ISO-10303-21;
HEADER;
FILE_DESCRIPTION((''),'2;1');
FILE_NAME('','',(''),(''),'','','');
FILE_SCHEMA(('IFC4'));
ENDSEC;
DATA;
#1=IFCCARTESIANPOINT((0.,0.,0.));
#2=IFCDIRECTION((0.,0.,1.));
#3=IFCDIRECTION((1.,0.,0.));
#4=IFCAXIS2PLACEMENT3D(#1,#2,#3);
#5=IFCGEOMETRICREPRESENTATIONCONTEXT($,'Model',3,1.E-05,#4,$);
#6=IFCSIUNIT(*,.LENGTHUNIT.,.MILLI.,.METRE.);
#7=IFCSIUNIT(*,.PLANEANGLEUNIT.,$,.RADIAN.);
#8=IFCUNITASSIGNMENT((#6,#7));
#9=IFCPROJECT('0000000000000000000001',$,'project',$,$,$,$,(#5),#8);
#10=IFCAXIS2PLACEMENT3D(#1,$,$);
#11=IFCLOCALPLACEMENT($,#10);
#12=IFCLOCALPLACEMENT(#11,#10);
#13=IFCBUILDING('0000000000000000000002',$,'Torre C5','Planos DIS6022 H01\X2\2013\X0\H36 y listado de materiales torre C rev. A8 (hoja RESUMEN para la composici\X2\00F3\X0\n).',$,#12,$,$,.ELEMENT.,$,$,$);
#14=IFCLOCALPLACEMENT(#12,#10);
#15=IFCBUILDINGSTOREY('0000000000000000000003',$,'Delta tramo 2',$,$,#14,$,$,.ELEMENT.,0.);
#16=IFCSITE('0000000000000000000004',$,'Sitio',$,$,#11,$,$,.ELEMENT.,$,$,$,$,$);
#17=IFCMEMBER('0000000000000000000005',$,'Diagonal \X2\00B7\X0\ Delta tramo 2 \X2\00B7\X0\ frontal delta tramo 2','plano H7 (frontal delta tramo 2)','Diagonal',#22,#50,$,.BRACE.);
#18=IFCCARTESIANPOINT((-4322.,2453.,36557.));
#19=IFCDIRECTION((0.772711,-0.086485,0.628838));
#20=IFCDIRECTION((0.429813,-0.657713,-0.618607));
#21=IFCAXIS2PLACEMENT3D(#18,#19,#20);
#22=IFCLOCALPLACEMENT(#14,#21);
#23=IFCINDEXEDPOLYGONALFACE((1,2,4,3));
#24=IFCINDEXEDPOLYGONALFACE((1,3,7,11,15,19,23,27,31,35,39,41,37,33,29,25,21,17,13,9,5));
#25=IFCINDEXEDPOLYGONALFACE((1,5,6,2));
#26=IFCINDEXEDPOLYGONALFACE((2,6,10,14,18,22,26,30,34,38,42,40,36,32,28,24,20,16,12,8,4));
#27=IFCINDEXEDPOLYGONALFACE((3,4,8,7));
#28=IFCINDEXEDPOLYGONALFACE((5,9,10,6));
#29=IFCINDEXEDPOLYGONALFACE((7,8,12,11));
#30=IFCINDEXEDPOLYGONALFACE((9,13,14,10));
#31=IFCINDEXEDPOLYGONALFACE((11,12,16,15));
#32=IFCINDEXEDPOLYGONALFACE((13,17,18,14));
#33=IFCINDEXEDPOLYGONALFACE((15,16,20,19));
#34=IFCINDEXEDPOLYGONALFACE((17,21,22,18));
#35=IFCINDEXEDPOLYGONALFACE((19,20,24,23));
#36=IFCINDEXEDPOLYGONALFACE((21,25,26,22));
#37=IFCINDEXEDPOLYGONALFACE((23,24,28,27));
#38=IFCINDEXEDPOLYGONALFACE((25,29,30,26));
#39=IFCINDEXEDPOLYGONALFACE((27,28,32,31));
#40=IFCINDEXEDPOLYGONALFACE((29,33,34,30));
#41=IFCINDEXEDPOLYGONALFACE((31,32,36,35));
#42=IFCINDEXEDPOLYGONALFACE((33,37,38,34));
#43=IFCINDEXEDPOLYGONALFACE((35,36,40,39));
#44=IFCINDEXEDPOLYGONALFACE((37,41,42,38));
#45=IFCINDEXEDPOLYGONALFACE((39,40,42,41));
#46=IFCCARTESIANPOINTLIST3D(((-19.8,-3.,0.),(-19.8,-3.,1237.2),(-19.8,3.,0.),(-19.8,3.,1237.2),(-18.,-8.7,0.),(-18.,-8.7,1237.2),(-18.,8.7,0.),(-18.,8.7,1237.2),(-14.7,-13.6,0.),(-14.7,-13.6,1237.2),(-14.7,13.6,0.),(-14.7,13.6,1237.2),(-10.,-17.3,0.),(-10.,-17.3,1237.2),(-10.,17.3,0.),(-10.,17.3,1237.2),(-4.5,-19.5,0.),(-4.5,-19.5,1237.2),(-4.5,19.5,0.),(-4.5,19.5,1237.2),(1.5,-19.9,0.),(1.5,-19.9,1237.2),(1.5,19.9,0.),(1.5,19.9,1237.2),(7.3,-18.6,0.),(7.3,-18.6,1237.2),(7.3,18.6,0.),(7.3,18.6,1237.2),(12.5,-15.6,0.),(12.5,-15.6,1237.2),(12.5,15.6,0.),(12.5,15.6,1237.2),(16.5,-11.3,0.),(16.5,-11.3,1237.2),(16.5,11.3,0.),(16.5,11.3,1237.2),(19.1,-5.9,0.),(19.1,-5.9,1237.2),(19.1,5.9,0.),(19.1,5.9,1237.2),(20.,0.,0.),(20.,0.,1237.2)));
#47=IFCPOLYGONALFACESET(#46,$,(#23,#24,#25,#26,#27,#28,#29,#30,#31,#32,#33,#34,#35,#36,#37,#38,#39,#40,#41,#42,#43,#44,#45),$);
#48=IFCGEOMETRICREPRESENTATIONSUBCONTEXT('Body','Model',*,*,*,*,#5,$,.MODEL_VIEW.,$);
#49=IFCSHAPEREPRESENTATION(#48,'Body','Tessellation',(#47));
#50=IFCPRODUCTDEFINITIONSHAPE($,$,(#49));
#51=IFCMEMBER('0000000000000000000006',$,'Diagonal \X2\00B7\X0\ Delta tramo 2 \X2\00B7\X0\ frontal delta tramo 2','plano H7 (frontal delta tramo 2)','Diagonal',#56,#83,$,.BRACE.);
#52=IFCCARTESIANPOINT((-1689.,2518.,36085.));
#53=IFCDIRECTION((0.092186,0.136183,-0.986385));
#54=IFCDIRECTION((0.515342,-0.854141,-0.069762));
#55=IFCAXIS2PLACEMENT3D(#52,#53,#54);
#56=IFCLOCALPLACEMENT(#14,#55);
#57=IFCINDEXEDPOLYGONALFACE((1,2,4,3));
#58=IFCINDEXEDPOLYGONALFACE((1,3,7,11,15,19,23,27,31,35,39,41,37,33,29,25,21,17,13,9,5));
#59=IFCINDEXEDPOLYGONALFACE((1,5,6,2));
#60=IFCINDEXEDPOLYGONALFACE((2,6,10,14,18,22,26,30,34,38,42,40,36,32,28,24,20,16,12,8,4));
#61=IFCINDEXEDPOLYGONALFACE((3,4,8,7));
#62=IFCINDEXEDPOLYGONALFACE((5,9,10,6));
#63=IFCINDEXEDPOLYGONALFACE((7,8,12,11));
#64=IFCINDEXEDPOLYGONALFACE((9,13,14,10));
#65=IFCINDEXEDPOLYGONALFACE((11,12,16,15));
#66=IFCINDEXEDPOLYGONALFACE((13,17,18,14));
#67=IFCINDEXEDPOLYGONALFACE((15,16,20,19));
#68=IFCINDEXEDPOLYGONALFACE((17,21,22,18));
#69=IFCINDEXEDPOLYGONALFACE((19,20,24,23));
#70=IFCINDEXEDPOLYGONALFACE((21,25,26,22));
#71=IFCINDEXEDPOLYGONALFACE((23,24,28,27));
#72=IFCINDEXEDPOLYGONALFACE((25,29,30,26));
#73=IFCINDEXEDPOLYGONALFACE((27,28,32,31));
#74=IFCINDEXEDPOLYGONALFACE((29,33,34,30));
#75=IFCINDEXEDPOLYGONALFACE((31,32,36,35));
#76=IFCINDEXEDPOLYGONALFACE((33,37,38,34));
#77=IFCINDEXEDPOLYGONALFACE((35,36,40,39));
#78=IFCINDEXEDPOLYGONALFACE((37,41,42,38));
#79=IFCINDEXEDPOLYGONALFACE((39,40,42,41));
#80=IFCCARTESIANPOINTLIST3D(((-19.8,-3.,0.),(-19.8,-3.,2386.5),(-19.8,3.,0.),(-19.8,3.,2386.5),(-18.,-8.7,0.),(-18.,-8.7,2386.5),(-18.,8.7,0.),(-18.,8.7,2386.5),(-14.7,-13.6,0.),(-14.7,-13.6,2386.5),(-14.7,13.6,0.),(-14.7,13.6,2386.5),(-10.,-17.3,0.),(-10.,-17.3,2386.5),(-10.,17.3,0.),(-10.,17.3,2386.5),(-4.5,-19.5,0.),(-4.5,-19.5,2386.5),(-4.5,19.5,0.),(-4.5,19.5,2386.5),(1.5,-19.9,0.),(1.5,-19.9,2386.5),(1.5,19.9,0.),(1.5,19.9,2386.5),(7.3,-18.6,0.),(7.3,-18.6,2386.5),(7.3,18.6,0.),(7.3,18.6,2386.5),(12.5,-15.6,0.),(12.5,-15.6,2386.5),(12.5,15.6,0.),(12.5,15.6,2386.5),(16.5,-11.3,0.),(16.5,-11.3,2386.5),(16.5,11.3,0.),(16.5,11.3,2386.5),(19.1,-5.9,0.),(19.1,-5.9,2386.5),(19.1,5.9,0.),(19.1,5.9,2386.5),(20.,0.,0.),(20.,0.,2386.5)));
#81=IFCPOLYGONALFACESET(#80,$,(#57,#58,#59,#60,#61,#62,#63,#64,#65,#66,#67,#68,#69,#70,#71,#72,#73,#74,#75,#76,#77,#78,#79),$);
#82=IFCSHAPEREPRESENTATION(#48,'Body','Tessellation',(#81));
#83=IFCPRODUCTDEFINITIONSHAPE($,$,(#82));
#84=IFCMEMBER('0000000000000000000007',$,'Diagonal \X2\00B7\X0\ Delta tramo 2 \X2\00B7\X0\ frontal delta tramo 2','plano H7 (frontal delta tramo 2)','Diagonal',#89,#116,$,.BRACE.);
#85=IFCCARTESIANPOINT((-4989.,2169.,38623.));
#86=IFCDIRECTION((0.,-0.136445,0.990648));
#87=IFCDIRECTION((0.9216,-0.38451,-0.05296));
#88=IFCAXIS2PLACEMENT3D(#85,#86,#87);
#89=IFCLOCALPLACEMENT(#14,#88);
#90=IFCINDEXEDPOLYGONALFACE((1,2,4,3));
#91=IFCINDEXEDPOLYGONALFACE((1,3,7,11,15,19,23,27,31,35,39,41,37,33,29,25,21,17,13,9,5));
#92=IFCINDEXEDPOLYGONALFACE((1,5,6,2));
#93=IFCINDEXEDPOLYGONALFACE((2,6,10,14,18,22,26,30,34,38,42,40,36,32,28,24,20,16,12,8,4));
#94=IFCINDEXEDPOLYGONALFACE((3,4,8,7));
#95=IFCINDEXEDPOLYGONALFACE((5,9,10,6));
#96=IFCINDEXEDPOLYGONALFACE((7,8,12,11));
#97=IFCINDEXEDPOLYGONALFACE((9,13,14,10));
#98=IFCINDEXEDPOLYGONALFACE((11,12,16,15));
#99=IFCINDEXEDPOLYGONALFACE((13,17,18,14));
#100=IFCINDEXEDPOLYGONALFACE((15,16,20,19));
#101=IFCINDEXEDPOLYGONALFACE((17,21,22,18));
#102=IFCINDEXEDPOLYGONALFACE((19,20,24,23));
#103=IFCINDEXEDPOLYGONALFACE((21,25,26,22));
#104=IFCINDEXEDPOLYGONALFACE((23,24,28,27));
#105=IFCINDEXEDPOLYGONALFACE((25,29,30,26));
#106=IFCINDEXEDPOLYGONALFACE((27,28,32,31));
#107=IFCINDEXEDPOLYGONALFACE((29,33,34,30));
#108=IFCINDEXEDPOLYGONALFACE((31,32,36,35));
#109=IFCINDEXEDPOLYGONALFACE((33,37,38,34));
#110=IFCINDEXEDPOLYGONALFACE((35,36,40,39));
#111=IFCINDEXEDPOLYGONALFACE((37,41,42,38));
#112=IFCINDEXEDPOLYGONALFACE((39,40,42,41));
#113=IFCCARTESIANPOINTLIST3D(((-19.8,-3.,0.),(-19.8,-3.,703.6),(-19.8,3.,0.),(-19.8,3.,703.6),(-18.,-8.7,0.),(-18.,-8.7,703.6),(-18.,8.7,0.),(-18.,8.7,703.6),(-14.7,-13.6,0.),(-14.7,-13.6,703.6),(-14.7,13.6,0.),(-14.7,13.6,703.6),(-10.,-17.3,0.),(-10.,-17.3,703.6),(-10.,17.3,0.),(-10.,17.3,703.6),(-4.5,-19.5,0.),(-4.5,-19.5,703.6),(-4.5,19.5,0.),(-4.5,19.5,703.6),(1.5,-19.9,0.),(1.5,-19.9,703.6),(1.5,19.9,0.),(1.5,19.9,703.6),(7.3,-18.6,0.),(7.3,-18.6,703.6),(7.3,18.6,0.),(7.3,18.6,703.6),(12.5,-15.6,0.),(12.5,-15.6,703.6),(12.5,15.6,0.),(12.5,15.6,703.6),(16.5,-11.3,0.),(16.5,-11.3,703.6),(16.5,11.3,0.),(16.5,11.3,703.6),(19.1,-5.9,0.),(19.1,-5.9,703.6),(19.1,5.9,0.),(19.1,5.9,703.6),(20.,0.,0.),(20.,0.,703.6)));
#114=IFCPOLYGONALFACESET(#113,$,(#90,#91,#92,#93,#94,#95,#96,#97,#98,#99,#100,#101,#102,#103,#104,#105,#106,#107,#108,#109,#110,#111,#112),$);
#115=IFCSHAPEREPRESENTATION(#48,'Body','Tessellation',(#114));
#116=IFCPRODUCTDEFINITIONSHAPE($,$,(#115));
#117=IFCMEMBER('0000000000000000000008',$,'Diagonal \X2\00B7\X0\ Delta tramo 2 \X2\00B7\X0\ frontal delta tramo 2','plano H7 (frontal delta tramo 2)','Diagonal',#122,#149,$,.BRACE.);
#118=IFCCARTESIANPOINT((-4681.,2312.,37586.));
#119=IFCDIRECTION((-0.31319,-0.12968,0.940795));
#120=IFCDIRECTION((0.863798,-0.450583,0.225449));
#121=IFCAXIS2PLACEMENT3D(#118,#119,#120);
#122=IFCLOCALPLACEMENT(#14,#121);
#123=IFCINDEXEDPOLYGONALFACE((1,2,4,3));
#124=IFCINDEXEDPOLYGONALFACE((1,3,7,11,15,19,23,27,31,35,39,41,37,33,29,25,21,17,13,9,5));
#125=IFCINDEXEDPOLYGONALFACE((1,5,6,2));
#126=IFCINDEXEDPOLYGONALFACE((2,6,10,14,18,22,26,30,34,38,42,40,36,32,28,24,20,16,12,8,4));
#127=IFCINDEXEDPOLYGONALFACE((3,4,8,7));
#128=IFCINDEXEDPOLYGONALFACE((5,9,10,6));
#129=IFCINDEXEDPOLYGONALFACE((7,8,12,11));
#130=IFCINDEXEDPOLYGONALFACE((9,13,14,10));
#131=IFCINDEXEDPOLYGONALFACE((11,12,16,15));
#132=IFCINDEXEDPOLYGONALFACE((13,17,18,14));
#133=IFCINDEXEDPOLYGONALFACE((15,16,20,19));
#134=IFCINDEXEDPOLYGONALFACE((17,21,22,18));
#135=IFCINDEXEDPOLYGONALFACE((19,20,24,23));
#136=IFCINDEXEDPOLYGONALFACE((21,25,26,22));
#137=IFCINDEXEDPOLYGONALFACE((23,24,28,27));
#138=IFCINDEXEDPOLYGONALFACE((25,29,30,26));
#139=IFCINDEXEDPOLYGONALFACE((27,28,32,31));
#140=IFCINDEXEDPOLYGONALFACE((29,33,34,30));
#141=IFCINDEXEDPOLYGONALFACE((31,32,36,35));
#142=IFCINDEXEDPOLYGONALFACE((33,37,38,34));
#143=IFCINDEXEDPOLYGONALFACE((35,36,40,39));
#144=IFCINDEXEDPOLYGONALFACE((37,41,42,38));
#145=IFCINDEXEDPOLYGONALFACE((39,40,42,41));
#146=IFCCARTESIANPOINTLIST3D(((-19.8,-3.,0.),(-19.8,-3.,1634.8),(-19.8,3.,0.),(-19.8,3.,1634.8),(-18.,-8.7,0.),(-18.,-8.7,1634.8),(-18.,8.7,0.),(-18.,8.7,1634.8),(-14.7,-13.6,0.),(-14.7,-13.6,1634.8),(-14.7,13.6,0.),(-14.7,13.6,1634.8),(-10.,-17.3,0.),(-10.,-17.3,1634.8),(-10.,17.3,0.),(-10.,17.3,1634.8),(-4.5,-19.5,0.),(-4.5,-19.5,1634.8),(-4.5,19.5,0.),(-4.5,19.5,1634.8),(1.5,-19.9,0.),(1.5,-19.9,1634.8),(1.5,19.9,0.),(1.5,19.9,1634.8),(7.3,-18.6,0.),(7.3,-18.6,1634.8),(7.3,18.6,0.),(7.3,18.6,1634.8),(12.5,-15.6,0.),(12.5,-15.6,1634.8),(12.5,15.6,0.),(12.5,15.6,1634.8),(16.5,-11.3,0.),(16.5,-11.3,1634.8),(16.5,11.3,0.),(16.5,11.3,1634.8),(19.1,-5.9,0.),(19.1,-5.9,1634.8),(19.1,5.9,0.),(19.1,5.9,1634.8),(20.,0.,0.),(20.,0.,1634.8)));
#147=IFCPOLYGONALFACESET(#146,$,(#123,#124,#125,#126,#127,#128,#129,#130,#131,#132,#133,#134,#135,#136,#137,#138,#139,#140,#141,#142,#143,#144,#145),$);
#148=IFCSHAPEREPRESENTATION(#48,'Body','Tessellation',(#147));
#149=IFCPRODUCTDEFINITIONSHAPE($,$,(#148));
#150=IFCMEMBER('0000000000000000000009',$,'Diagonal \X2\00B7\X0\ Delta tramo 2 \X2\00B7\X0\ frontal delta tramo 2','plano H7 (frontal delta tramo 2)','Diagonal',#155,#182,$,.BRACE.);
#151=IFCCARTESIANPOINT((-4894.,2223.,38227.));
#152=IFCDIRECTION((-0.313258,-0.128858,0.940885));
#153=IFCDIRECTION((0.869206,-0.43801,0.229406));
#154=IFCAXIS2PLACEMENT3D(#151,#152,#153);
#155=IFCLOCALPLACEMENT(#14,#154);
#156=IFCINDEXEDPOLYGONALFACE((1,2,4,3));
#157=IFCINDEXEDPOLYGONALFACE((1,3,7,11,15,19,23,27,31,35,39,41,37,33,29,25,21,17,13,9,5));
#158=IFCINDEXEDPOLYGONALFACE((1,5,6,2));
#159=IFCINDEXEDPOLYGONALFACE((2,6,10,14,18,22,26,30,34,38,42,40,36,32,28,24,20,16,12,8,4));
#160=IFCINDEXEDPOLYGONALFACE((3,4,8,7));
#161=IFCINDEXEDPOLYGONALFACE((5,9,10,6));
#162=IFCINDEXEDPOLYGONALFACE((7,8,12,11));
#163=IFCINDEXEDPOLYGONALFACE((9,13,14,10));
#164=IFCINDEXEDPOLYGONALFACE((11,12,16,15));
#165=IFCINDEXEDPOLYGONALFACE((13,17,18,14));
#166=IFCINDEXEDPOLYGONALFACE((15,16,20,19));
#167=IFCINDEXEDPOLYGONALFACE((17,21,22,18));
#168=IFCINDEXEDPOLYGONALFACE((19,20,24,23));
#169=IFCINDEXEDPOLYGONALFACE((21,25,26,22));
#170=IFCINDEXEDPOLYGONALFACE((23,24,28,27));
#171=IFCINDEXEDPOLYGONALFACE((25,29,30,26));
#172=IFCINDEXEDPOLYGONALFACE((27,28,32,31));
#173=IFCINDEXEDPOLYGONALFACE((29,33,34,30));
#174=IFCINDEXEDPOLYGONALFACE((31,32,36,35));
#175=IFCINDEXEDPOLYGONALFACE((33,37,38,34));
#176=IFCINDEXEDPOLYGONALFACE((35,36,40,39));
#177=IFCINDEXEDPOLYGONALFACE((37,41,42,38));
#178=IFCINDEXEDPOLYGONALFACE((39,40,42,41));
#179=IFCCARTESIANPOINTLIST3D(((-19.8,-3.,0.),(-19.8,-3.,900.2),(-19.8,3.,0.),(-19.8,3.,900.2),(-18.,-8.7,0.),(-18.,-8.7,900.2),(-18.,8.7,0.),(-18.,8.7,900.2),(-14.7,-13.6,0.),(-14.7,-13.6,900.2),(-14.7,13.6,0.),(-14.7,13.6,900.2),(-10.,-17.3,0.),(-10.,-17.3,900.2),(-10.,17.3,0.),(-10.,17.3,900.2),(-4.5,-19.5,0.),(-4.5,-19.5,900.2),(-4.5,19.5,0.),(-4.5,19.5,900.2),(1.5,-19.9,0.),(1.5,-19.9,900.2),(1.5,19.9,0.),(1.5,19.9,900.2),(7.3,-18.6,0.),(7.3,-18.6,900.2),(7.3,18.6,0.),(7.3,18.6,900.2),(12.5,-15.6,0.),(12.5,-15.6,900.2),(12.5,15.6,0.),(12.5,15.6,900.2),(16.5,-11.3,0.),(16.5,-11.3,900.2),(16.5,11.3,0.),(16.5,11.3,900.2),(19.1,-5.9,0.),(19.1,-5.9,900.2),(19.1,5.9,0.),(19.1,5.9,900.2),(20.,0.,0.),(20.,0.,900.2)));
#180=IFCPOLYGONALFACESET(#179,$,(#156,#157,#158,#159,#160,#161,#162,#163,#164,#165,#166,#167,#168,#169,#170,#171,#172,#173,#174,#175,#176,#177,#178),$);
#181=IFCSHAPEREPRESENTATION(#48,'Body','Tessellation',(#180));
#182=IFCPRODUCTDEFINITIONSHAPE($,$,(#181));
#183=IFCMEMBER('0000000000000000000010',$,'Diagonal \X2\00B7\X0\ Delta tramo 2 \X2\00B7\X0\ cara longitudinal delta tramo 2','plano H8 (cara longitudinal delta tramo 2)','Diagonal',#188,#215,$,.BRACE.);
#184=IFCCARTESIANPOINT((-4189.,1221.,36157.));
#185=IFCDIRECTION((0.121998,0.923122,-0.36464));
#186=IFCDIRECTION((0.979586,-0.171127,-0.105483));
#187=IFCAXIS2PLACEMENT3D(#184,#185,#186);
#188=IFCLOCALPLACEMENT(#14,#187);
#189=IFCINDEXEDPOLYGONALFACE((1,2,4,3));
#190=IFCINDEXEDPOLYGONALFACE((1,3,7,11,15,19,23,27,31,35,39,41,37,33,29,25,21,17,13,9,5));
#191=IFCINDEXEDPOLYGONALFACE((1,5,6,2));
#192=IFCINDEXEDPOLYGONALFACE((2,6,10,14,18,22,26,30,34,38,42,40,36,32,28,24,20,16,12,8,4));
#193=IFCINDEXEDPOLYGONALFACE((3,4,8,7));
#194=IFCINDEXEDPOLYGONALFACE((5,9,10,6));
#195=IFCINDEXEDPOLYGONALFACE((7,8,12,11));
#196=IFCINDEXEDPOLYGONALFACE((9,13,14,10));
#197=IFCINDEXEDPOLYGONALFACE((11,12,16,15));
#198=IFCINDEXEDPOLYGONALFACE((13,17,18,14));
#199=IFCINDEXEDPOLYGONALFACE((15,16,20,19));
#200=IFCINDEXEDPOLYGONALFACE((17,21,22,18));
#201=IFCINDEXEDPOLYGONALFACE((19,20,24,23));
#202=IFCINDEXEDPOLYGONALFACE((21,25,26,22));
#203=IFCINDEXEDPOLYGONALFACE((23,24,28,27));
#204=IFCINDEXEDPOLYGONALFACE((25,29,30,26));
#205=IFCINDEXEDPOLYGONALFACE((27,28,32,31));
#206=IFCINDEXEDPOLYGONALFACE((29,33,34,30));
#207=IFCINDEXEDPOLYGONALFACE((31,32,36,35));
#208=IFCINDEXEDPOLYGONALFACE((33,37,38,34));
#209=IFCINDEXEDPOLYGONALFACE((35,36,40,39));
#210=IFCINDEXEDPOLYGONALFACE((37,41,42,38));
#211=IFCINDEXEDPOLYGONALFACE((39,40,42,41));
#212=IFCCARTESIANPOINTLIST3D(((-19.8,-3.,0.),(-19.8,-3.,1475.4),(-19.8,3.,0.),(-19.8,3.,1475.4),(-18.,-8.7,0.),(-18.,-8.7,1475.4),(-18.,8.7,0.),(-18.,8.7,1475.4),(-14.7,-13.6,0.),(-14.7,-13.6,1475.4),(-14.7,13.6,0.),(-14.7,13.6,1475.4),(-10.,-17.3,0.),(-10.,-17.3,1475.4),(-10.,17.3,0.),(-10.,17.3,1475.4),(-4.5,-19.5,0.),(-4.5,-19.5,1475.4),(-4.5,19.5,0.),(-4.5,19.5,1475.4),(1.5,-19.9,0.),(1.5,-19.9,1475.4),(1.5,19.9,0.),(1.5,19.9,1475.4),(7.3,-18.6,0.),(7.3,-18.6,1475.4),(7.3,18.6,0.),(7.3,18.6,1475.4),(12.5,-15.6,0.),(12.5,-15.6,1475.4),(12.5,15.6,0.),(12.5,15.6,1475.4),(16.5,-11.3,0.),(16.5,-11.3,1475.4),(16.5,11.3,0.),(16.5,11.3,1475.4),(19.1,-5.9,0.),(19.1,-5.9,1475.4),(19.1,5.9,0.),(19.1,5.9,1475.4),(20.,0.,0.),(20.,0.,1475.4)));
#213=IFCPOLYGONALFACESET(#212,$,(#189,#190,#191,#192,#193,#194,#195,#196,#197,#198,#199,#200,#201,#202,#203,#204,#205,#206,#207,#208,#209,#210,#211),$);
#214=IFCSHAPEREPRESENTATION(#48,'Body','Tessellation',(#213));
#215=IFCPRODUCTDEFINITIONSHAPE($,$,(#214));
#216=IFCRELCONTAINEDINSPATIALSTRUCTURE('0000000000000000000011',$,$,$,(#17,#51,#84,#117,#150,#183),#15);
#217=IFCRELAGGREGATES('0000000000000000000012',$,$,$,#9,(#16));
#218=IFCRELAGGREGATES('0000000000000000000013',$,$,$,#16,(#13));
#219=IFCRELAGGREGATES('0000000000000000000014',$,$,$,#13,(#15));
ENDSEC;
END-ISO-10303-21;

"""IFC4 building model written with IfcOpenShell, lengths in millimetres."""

from ifc_helpers import new_model, si_unit, frame, origin, origin_with_axes, place, context, subcontext, project, spatial, circle, extrude, element, save


model = new_model("IFC4")

# Units and contexts
model_context = context("Model", 3, precision=1e-05, world=origin_with_axes())
body_context = subcontext(model_context, "Body", "Model", "MODEL_VIEW")
ifc_project = project(units=[si_unit("LENGTHUNIT", "METRE", prefix="MILLI"), si_unit("PLANEANGLEUNIT", "RADIAN")], contexts=[model_context])

# Site, building, storey
site_placement = place(None, origin())
site = spatial("IfcSite", under=ifc_project, at=site_placement, Name="Sitio", CompositionType="ELEMENT")
building_placement = place(site_placement, origin())
building = spatial("IfcBuilding", under=site, at=building_placement, Name="Torre C5", Description="Planos DIS6022 H01–H36 y listado de materiales torre C rev. A8 (hoja RESUMEN para la composición).", CompositionType="ELEMENT")
storey_placement = place(building_placement, origin())
storey = spatial("IfcBuildingStorey", under=building, at=storey_placement, Name="Delta tramo 2", CompositionType="ELEMENT", Elevation=0.0)

# Members
member_1_placement = place(storey_placement, frame((-4322.0, 2453.0, 36557.0), z_axis=(0.772711, -0.086485, 0.628838), x_axis=(0.429813, -0.657713, -0.618607)))
element("IfcMember", 1, at=member_1_placement, inside=storey, Name="Diagonal · Delta tramo 2 · frontal delta tramo 2", Description="plano H7 (frontal delta tramo 2)", ObjectType="Diagonal", PredefinedType="BRACE", context=body_context, shape_type="SweptSolid", body=[
    extrude(circle(Radius=20.0), None, (0.0, 0.0, 1.0), 1237.2),
])
member_2_placement = place(storey_placement, frame((-1689.0, 2518.0, 36085.0), z_axis=(0.092186, 0.136183, -0.986385), x_axis=(0.515342, -0.854141, -0.069762)))
element("IfcMember", 2, at=member_2_placement, inside=storey, Name="Diagonal · Delta tramo 2 · frontal delta tramo 2", Description="plano H7 (frontal delta tramo 2)", ObjectType="Diagonal", PredefinedType="BRACE", context=body_context, shape_type="SweptSolid", body=[
    extrude(circle(Radius=20.0), None, (0.0, 0.0, 1.0), 2386.5),
])
member_3_placement = place(storey_placement, frame((-4989.0, 2169.0, 38623.0), z_axis=(0.0, -0.136445, 0.990648), x_axis=(0.9216, -0.38451, -0.05296)))
element("IfcMember", 3, at=member_3_placement, inside=storey, Name="Diagonal · Delta tramo 2 · frontal delta tramo 2", Description="plano H7 (frontal delta tramo 2)", ObjectType="Diagonal", PredefinedType="BRACE", context=body_context, shape_type="SweptSolid", body=[
    extrude(circle(Radius=20.0), None, (0.0, 0.0, 1.0), 703.6),
])
member_4_placement = place(storey_placement, frame((-4681.0, 2312.0, 37586.0), z_axis=(-0.31319, -0.12968, 0.940795), x_axis=(0.863798, -0.450583, 0.225449)))
element("IfcMember", 4, at=member_4_placement, inside=storey, Name="Diagonal · Delta tramo 2 · frontal delta tramo 2", Description="plano H7 (frontal delta tramo 2)", ObjectType="Diagonal", PredefinedType="BRACE", context=body_context, shape_type="SweptSolid", body=[
    extrude(circle(Radius=20.0), None, (0.0, 0.0, 1.0), 1634.8),
])
member_5_placement = place(storey_placement, frame((-4894.0, 2223.0, 38227.0), z_axis=(-0.313258, -0.128858, 0.940885), x_axis=(0.869206, -0.43801, 0.229406)))
element("IfcMember", 5, at=member_5_placement, inside=storey, Name="Diagonal · Delta tramo 2 · frontal delta tramo 2", Description="plano H7 (frontal delta tramo 2)", ObjectType="Diagonal", PredefinedType="BRACE", context=body_context, shape_type="SweptSolid", body=[
    extrude(circle(Radius=20.0), None, (0.0, 0.0, 1.0), 900.2),
])
member_6_placement = place(storey_placement, frame((-4189.0, 1221.0, 36157.0), z_axis=(0.121998, 0.923122, -0.36464), x_axis=(0.979586, -0.171127, -0.105483)))
element("IfcMember", 6, at=member_6_placement, inside=storey, Name="Diagonal · Delta tramo 2 · cara longitudinal delta tramo 2", Description="plano H8 (cara longitudinal delta tramo 2)", ObjectType="Diagonal", PredefinedType="BRACE", context=body_context, shape_type="SweptSolid", body=[
    extrude(circle(Radius=20.0), None, (0.0, 0.0, 1.0), 1475.4),
])

save(model, "model.ifc")
